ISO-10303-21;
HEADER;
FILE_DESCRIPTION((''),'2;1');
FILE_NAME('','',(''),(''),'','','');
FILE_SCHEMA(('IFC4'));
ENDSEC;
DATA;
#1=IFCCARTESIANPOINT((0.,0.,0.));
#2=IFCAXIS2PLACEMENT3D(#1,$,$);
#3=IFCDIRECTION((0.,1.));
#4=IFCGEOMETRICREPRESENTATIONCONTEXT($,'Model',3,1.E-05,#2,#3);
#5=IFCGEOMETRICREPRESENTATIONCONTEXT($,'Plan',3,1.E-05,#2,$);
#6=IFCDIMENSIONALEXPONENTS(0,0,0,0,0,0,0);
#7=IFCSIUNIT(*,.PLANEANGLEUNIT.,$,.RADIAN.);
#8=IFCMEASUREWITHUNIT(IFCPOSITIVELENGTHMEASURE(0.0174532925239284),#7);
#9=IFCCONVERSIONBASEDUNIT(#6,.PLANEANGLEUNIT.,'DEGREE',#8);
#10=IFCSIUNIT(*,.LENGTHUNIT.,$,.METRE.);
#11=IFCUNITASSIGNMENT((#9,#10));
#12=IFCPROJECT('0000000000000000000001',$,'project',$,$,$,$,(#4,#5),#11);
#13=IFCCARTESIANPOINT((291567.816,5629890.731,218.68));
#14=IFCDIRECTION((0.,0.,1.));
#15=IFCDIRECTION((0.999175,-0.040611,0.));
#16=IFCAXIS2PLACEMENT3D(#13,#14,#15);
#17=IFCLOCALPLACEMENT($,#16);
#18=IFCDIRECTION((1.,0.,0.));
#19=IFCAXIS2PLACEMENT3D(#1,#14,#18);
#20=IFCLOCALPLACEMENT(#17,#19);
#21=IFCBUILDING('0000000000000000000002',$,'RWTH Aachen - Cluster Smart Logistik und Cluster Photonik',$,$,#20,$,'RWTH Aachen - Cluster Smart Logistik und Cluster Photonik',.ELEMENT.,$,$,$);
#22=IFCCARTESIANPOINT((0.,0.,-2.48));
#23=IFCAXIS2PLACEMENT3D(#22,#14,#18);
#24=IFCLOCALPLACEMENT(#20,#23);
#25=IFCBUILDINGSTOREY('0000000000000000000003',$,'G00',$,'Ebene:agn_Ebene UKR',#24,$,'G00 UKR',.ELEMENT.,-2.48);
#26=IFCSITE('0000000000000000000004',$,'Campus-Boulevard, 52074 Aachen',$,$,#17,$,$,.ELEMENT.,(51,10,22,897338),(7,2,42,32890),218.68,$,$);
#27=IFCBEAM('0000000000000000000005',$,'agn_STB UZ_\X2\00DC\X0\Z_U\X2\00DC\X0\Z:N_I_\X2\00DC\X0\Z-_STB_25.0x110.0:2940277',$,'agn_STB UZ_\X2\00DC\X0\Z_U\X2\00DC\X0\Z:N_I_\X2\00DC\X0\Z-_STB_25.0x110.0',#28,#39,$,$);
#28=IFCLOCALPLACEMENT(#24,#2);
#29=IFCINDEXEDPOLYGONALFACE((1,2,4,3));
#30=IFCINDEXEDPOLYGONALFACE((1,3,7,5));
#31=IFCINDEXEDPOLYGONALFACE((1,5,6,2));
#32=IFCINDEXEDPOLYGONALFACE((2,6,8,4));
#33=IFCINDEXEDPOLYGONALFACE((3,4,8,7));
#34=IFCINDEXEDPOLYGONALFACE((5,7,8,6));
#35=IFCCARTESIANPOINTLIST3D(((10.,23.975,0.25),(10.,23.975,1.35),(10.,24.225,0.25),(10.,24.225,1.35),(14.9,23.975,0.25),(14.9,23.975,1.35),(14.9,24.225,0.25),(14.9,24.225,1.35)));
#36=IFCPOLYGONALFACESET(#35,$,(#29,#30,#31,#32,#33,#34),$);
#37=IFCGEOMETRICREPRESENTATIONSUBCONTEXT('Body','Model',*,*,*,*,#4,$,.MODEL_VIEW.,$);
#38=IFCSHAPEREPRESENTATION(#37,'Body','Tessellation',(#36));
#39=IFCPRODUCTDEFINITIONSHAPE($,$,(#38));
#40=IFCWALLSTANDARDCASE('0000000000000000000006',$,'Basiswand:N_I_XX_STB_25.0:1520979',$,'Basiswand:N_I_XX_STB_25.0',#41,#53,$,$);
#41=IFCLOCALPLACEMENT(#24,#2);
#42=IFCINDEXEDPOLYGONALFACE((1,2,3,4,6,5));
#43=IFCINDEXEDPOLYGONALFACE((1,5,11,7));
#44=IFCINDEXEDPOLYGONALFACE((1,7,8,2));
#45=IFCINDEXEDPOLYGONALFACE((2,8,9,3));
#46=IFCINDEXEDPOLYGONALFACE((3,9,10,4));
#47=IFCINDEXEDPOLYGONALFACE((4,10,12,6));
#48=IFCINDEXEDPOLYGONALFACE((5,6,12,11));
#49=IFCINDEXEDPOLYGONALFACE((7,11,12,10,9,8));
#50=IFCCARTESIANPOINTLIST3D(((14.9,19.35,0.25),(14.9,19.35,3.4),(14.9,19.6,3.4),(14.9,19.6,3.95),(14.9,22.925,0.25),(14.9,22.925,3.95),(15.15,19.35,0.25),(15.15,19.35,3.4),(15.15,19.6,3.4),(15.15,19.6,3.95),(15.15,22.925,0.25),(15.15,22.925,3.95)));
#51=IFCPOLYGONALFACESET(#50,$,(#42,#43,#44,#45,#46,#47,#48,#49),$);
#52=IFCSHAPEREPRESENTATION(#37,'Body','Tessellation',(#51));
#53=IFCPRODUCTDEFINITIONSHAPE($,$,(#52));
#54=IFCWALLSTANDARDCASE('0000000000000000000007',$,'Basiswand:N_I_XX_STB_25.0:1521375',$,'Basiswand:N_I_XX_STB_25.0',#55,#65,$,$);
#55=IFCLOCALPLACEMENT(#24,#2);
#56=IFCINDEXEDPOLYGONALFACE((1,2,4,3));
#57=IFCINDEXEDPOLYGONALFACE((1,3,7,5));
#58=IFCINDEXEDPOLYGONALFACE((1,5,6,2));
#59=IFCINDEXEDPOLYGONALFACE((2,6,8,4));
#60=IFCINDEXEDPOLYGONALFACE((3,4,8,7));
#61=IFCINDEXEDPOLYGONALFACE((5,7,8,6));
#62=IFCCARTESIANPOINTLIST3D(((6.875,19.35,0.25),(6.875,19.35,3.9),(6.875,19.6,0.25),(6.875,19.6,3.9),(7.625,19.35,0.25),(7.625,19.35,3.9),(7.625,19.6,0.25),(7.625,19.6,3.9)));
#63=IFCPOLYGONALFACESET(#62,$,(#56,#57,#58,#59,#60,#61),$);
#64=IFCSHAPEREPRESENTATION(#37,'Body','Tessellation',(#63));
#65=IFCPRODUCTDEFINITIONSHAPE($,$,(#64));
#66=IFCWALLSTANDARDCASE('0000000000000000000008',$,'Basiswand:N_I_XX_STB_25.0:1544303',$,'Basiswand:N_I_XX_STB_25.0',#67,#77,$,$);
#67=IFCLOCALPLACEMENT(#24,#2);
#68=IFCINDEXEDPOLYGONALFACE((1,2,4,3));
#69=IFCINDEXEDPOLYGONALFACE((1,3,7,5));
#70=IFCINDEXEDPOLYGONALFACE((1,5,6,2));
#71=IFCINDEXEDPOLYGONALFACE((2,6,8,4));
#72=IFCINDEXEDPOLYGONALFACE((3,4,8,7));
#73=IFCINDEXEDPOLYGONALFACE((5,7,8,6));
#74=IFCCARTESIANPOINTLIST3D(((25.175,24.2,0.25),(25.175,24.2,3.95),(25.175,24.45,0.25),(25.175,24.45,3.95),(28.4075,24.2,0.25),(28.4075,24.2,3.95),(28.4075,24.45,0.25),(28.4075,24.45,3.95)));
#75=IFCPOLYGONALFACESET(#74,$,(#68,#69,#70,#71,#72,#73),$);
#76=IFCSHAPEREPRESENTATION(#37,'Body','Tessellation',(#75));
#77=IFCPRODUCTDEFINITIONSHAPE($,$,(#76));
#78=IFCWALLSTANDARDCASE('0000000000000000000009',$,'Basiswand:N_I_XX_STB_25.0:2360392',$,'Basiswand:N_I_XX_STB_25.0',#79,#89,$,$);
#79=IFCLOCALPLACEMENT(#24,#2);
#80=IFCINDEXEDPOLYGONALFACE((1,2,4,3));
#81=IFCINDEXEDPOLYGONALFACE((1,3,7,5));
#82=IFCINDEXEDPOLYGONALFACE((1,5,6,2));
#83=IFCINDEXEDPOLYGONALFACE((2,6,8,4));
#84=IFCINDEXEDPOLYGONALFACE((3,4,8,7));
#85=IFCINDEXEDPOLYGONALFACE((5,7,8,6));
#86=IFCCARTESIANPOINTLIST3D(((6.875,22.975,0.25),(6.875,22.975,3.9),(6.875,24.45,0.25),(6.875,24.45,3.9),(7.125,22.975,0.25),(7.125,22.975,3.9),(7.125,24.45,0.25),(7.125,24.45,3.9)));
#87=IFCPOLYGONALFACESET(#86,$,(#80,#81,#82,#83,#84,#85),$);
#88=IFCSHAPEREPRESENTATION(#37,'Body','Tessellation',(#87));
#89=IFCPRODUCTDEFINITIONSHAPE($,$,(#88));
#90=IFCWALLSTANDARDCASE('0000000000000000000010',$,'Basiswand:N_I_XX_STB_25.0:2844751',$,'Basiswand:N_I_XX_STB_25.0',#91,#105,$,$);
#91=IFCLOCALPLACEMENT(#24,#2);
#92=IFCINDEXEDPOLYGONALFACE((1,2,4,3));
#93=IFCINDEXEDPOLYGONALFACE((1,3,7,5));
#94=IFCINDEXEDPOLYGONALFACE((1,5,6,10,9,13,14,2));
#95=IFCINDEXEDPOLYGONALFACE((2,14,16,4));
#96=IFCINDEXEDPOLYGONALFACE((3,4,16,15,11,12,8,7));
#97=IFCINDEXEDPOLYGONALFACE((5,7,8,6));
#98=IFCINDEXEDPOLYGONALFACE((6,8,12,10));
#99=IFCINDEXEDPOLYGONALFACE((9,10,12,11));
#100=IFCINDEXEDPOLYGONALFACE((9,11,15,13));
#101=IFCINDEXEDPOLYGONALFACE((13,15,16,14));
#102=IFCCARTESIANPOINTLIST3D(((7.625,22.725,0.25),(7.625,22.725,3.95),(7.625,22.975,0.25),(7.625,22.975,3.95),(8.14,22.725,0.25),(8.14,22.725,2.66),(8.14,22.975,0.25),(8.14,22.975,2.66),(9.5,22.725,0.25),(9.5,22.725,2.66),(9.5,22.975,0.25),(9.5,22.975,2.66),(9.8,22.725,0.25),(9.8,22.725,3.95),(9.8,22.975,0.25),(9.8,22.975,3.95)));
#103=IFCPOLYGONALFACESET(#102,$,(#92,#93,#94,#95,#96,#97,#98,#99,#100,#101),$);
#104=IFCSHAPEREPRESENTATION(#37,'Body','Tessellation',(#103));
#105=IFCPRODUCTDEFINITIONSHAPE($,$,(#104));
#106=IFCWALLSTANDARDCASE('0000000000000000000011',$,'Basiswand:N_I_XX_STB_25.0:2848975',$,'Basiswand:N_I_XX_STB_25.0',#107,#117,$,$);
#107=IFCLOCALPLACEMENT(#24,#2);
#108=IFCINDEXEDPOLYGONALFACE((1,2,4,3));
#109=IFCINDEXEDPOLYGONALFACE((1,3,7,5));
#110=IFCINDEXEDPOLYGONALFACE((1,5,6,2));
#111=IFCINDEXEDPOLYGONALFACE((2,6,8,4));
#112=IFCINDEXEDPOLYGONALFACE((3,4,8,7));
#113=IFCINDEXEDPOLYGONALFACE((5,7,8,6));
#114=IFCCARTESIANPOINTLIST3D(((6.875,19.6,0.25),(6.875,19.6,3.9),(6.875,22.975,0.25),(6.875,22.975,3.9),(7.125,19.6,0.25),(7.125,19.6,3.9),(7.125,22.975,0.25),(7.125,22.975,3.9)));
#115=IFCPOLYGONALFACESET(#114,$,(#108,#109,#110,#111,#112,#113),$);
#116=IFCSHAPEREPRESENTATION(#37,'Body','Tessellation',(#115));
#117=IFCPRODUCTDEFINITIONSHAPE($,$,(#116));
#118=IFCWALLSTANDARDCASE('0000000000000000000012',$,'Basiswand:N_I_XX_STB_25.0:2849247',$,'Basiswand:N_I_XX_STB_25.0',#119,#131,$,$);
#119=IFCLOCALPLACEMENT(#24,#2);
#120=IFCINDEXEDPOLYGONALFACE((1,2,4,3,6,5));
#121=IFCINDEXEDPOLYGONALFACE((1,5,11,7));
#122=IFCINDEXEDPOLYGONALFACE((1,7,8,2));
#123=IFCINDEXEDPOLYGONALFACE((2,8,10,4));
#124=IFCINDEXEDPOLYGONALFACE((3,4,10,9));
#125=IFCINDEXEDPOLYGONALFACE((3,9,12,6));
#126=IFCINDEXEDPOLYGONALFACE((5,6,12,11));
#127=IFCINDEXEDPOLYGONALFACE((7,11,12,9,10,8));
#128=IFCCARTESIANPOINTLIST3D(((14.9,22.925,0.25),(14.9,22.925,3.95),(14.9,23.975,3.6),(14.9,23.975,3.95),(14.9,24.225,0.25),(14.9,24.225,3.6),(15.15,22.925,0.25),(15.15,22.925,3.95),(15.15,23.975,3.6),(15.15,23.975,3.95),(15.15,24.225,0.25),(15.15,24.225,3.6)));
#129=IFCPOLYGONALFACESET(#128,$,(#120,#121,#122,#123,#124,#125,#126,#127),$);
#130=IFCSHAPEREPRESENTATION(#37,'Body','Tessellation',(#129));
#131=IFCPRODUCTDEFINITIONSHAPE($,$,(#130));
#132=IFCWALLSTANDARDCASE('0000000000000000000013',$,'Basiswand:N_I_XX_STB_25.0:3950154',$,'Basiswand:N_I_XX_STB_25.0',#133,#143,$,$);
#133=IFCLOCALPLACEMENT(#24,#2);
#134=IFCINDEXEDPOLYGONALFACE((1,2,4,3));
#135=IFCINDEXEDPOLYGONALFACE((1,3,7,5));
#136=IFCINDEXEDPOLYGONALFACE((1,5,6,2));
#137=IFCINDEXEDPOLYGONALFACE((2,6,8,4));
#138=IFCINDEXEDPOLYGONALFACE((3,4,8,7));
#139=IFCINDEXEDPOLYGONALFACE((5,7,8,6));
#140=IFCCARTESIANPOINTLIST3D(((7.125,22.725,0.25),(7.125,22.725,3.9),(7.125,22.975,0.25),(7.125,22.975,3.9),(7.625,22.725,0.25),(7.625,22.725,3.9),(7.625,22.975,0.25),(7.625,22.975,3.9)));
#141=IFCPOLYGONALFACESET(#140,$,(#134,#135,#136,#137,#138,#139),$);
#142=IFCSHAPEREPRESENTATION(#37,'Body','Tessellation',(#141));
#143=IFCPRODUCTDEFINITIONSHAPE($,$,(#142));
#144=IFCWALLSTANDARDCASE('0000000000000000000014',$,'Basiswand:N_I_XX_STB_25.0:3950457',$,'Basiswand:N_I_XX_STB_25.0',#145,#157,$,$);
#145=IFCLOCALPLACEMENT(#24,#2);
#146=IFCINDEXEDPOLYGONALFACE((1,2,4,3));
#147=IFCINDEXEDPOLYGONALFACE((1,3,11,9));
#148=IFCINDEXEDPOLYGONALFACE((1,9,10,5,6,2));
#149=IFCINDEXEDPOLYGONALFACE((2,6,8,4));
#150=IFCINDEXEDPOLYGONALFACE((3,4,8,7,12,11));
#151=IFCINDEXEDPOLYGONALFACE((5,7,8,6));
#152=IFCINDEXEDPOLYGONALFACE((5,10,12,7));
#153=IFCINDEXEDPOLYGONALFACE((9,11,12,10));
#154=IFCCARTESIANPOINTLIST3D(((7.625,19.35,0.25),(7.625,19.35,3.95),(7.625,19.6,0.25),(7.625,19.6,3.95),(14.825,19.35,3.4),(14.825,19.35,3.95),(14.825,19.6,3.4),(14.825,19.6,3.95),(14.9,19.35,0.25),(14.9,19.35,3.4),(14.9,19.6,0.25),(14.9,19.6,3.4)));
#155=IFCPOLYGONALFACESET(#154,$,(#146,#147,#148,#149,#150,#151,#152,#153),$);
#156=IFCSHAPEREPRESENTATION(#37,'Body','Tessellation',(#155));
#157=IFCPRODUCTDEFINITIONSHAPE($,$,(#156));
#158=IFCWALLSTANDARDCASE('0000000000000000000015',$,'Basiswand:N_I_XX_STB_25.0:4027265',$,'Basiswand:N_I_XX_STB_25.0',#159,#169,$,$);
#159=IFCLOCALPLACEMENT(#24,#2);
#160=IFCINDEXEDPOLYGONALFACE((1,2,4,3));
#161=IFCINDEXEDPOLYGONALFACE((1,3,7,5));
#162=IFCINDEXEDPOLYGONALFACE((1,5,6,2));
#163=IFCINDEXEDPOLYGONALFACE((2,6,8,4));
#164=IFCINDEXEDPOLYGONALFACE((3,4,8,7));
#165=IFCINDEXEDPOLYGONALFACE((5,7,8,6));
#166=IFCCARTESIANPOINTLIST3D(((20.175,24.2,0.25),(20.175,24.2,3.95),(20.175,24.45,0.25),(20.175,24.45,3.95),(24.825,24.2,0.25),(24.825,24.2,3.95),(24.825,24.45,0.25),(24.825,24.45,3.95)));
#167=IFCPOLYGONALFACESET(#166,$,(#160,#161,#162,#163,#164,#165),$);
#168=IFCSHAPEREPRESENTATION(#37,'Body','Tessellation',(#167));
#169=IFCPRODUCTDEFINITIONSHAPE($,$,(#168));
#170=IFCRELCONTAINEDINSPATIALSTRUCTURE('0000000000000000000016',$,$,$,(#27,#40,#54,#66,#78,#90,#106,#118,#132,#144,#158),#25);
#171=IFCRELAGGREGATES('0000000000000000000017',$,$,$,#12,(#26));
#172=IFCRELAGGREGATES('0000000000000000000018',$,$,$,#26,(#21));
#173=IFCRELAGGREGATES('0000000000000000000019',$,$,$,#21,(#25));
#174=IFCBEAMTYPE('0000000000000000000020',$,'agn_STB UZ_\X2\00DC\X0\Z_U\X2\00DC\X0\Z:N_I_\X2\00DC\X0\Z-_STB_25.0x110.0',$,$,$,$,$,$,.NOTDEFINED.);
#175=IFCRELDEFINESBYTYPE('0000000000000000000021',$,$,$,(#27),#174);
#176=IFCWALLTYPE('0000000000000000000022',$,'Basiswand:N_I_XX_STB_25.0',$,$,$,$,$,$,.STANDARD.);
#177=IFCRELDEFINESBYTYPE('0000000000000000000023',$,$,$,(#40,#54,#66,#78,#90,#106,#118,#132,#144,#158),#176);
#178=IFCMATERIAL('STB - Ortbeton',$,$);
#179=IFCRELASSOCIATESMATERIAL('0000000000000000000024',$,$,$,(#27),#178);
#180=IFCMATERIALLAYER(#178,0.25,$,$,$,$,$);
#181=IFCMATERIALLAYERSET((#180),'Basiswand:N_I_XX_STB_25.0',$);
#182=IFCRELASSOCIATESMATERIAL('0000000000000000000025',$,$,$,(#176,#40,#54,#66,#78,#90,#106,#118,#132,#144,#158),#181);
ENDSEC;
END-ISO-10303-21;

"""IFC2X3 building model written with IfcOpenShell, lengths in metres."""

from ifc_helpers import new_model, entity, si_unit, converted_unit, direction, frame, frame_2d, origin, origin_with_axes, place, context, subcontext, project, spatial, polyline, rectangle, extrude, clip, bounded_halfspace, material, layer, layer_set, layer_usage, type_object, element, save


model = new_model("IFC2X3")

# Units and contexts
model_context = context("Model", 3, precision=1e-05, world=origin(), true_north=direction((0.0, 1.0)))
plan_context = context("Plan", 3, precision=1e-05, world=origin())
body_context = subcontext(model_context, "Body", "Model", "MODEL_VIEW")
ifc_project = project(units=[converted_unit("PLANEANGLEUNIT", "DEGREE", entity("IfcPositiveLengthMeasure", 0.0174532925239284), si_unit("PLANEANGLEUNIT", "RADIAN"), dimensions=[0, 0, 0, 0, 0, 0, 0]), si_unit("LENGTHUNIT", "METRE")], contexts=[model_context, plan_context])

# Site, building, storey
site_placement = place(None, frame((291567.816, 5629890.731, 218.68), z_axis=(0.0, 0.0, 1.0), x_axis=(0.999175, -0.040611, 0.0)))
site = spatial("IfcSite", under=ifc_project, at=site_placement, Name="Campus-Boulevard, 52074 Aachen", CompositionType="ELEMENT", RefLatitude=(51, 10, 22, 897338), RefLongitude=(7, 2, 42, 32890), RefElevation=218.68)
building_placement = place(site_placement, origin_with_axes())
building = spatial("IfcBuilding", under=site, at=building_placement, Name="RWTH Aachen - Cluster Smart Logistik und Cluster Photonik", LongName="RWTH Aachen - Cluster Smart Logistik und Cluster Photonik", CompositionType="ELEMENT")
storey_placement = place(building_placement, frame((0.0, 0.0, -2.48), z_axis=(0.0, 0.0, 1.0), x_axis=(1.0, 0.0, 0.0)))
storey = spatial("IfcBuildingStorey", under=building, at=storey_placement, Name="G00", ObjectType="Ebene:agn_Ebene UKR", LongName="G00 UKR", CompositionType="ELEMENT", Elevation=-2.48)

# Beam
ifc_material_1 = material(Name="STB - Ortbeton")
beam_type_1 = type_object("IfcBeamType", Name="agn_STB UZ_ÜZ_UÜZ:N_I_ÜZ-_STB_25.0x110.0", PredefinedType="NOTDEFINED")
beam_1_placement = place(storey_placement, frame((15.025, 24.1, 0.25), z_axis=(0.0, 0.0, 1.0), x_axis=(-1.0, 0.0, 0.0)))
element("IfcBeam", 1, at=beam_1_placement, inside=storey, type_object=beam_type_1, material=ifc_material_1, Name="agn_STB UZ_ÜZ_UÜZ:N_I_ÜZ-_STB_25.0x110.0:2940277", ObjectType="agn_STB UZ_ÜZ_UÜZ:N_I_ÜZ-_STB_25.0x110.0", context=body_context, shape_type="SweptSolid", body=[
    extrude(rectangle(XDim=1.1, YDim=0.25, at=frame_2d((0.0, 0.0), x_axis=(1.0, 0.0))), frame((0.125, 0.0, 0.55), z_axis=(1.0, 0.0, 0.0), x_axis=(0.0, 0.0, -1.0)), (0.0, 0.0, 1.0), 4.9),
])

# Walls
ifc_layer_1 = layer(ifc_material_1, 0.25)
ifc_layer_set_1 = layer_set([ifc_layer_1], Name="Basiswand:N_I_XX_STB_25.0")
ifc_layer_usage_1 = layer_usage(ifc_layer_set_1, "AXIS2", "NEGATIVE", 0.125)
wall_type_1 = type_object("IfcWallType", Name="Basiswand:N_I_XX_STB_25.0", PredefinedType="STANDARD", material=ifc_layer_set_1)
wall_1_placement = place(storey_placement, frame((15.025, 19.35, 0.25), z_axis=(0.0, 0.0, 1.0), x_axis=(0.0, 1.0, 0.0)))
element("IfcWallStandardCase", 2, at=wall_1_placement, inside=storey, type_object=wall_type_1, material=ifc_layer_usage_1, Name="Basiswand:N_I_XX_STB_25.0:1520979", ObjectType="Basiswand:N_I_XX_STB_25.0", context=body_context, shape_type="Clipping", body=[
    clip(clip(extrude(rectangle(XDim=3.575, YDim=0.25, at=frame_2d((1.7875, 0.0), x_axis=(-1.0, 0.0))), origin(), (0.0, 0.0, 1.0), 3.7), bounded_halfspace(frame((0.25, -0.125, 3.15), z_axis=(0.0, 0.0, 1.0), x_axis=(0.0, 1.0, 0.0)), False, frame((0.25, -0.125, 3.15), z_axis=(0.0, 0.0, 1.0), x_axis=(0.0, 1.0, 0.0)), polyline([(0.0, 0.0), (0.25, 0.0), (0.25, 0.25), (0.0, 0.25), (0.0, 0.0)]))), bounded_halfspace(frame((0.25, 0.125, 3.15), z_axis=(-1.0, 0.0, 0.0), x_axis=(0.0, -1.0, 0.0)), False, frame((0.25, 0.125, 3.15), z_axis=(-1.0, 0.0, 0.0), x_axis=(0.0, -1.0, 0.0)), polyline([(0.0, 0.0), (0.25, 0.0), (0.25, 0.55), (0.0, 0.55), (0.0, 0.0)]))),
])
ifc_layer_usage_2 = layer_usage(ifc_layer_set_1, "AXIS2", "NEGATIVE", 0.125)
wall_2_placement = place(storey_placement, frame((6.875, 19.475, 0.25), z_axis=(0.0, 0.0, 1.0), x_axis=(1.0, 0.0, 0.0)))
element("IfcWallStandardCase", 3, at=wall_2_placement, inside=storey, type_object=wall_type_1, material=ifc_layer_usage_2, Name="Basiswand:N_I_XX_STB_25.0:1521375", ObjectType="Basiswand:N_I_XX_STB_25.0", context=body_context, shape_type="SweptSolid", body=[
    extrude(rectangle(XDim=0.75, YDim=0.25, at=frame_2d((0.375, 0.0), x_axis=(-1.0, 0.0))), origin(), (0.0, 0.0, 1.0), 3.65),
])
ifc_layer_usage_3 = layer_usage(ifc_layer_set_1, "AXIS2", "NEGATIVE", 0.125)
wall_3_placement = place(storey_placement, frame((28.4075, 24.325, 0.25), z_axis=(0.0, 0.0, 1.0), x_axis=(-1.0, 0.0, 0.0)))
element("IfcWallStandardCase", 4, at=wall_3_placement, inside=storey, type_object=wall_type_1, material=ifc_layer_usage_3, Name="Basiswand:N_I_XX_STB_25.0:1544303", ObjectType="Basiswand:N_I_XX_STB_25.0", context=body_context, shape_type="SweptSolid", body=[
    extrude(rectangle(XDim=3.2325, YDim=0.25, at=frame_2d((1.6162, 0.0), x_axis=(-1.0, 0.0))), origin(), (0.0, 0.0, 1.0), 3.7),
])
ifc_layer_usage_4 = layer_usage(ifc_layer_set_1, "AXIS2", "NEGATIVE", 0.125)
wall_4_placement = place(storey_placement, frame((7.0, 24.45, 0.25), z_axis=(0.0, 0.0, 1.0), x_axis=(0.0, -1.0, 0.0)))
element("IfcWallStandardCase", 5, at=wall_4_placement, inside=storey, type_object=wall_type_1, material=ifc_layer_usage_4, Name="Basiswand:N_I_XX_STB_25.0:2360392", ObjectType="Basiswand:N_I_XX_STB_25.0", context=body_context, shape_type="SweptSolid", body=[
    extrude(rectangle(XDim=1.475, YDim=0.25, at=frame_2d((0.7375, 0.0), x_axis=(-1.0, 0.0))), origin(), (0.0, 0.0, 1.0), 3.65),
])

# Wall, opening
ifc_layer_usage_5 = layer_usage(ifc_layer_set_1, "AXIS2", "NEGATIVE", 0.125)
wall_5_placement = place(storey_placement, frame((9.8, 22.85, 0.25), z_axis=(0.0, 0.0, 1.0), x_axis=(-1.0, 0.0, 0.0)))
wall_5 = element("IfcWallStandardCase", 6, at=wall_5_placement, inside=storey, type_object=wall_type_1, material=ifc_layer_usage_5, Name="Basiswand:N_I_XX_STB_25.0:2844751", ObjectType="Basiswand:N_I_XX_STB_25.0", context=body_context, shape_type="SweptSolid", body=[
    extrude(rectangle(XDim=2.175, YDim=0.25, at=frame_2d((1.0875, 0.0), x_axis=(-1.0, 0.0))), origin(), (0.0, 0.0, 1.0), 3.7),
])
opening_1_placement = place(wall_5_placement, frame((1.66, 0.125, 0.0), z_axis=(0.0, 0.0, 1.0), x_axis=(1.0, 0.0, 0.0)))
element("IfcOpeningElement", 7, at=opening_1_placement, cuts=wall_5, ObjectType="Opening", context=body_context, shape_type="SweptSolid", body=[
    extrude(rectangle(XDim=2.41, YDim=1.36, at=frame_2d((1.205, 0.68), x_axis=(1.0, 0.0))), frame((0.0, 0.0, 0.0), z_axis=(0.0, -1.0, 0.0), x_axis=(0.0, 0.0, 1.0)), (0.0, 0.0, 1.0), 0.25),
])

# Walls
ifc_layer_usage_6 = layer_usage(ifc_layer_set_1, "AXIS2", "NEGATIVE", 0.125)
wall_6_placement = place(storey_placement, frame((7.0, 22.975, 0.25), z_axis=(0.0, 0.0, 1.0), x_axis=(0.0, -1.0, 0.0)))
element("IfcWallStandardCase", 8, at=wall_6_placement, inside=storey, type_object=wall_type_1, material=ifc_layer_usage_6, Name="Basiswand:N_I_XX_STB_25.0:2848975", ObjectType="Basiswand:N_I_XX_STB_25.0", context=body_context, shape_type="SweptSolid", body=[
    extrude(rectangle(XDim=3.375, YDim=0.25, at=frame_2d((1.6875, 0.0), x_axis=(-1.0, 0.0))), origin(), (0.0, 0.0, 1.0), 3.65),
])
ifc_layer_usage_7 = layer_usage(ifc_layer_set_1, "AXIS2", "NEGATIVE", 0.125)
wall_7_placement = place(storey_placement, frame((15.025, 22.925, 0.25), z_axis=(0.0, 0.0, 1.0), x_axis=(0.0, 1.0, 0.0)))
element("IfcWallStandardCase", 9, at=wall_7_placement, inside=storey, type_object=wall_type_1, material=ifc_layer_usage_7, Name="Basiswand:N_I_XX_STB_25.0:2849247", ObjectType="Basiswand:N_I_XX_STB_25.0", context=body_context, shape_type="Clipping", body=[
    clip(clip(extrude(rectangle(XDim=1.3, YDim=0.25, at=frame_2d((0.65, 0.0), x_axis=(-1.0, 0.0))), origin(), (0.0, 0.0, 1.0), 3.7), bounded_halfspace(frame((1.05, -0.125, 3.35), z_axis=(-1.0, 0.0, 0.0), x_axis=(0.0, 0.0, 1.0)), True, frame((1.05, -0.125, 3.35), z_axis=(-1.0, 0.0, 0.0), x_axis=(0.0, 0.0, 1.0)), polyline([(0.0, 0.0), (0.35, 0.0), (0.35, 0.25), (0.0, 0.25), (0.0, 0.0)]))), bounded_halfspace(frame((1.05, 0.125, 3.35), z_axis=(0.0, 0.0, -1.0), x_axis=(-1.0, 0.0, 0.0)), True, frame((1.05, 0.125, 3.35), z_axis=(0.0, 0.0, -1.0), x_axis=(-1.0, 0.0, 0.0)), polyline([(0.0, 0.0), (-0.25, 0.0), (-0.25, -0.25), (0.0, -0.25), (0.0, 0.0)]))),
])
ifc_layer_usage_8 = layer_usage(ifc_layer_set_1, "AXIS2", "NEGATIVE", 0.125)
wall_8_placement = place(storey_placement, frame((7.625, 22.85, 0.25), z_axis=(0.0, 0.0, 1.0), x_axis=(-1.0, 0.0, 0.0)))
element("IfcWallStandardCase", 10, at=wall_8_placement, inside=storey, type_object=wall_type_1, material=ifc_layer_usage_8, Name="Basiswand:N_I_XX_STB_25.0:3950154", ObjectType="Basiswand:N_I_XX_STB_25.0", context=body_context, shape_type="SweptSolid", body=[
    extrude(rectangle(XDim=0.5, YDim=0.25, at=frame_2d((0.25, 0.0), x_axis=(-1.0, 0.0))), origin(), (0.0, 0.0, 1.0), 3.65),
])
ifc_layer_usage_9 = layer_usage(ifc_layer_set_1, "AXIS2", "NEGATIVE", 0.125)
wall_9_placement = place(storey_placement, frame((7.625, 19.475, 0.25), z_axis=(0.0, 0.0, 1.0), x_axis=(1.0, 0.0, 0.0)))
element("IfcWallStandardCase", 11, at=wall_9_placement, inside=storey, type_object=wall_type_1, material=ifc_layer_usage_9, Name="Basiswand:N_I_XX_STB_25.0:3950457", ObjectType="Basiswand:N_I_XX_STB_25.0", context=body_context, shape_type="Clipping", body=[
    clip(clip(extrude(rectangle(XDim=7.275, YDim=0.25, at=frame_2d((3.6375, 0.0), x_axis=(-1.0, 0.0))), origin(), (0.0, 0.0, 1.0), 3.7), bounded_halfspace(frame((7.2, 0.125, 3.15), z_axis=(0.0, 0.0, 1.0), x_axis=(-1.0, 0.0, 0.0)), False, frame((7.2, 0.125, 3.15), z_axis=(0.0, 0.0, 1.0), x_axis=(-1.0, 0.0, 0.0)), polyline([(0.0, 0.0), (0.0, 0.25), (-0.075, 0.25), (-0.075, 0.0), (0.0, 0.0)]))), bounded_halfspace(frame((7.2, -0.125, 3.15), z_axis=(1.0, 0.0, 0.0), x_axis=(0.0, 0.0, 1.0)), False, frame((7.2, -0.125, 3.15), z_axis=(1.0, 0.0, 0.0), x_axis=(0.0, 0.0, 1.0)), polyline([(0.0, 0.0), (0.0, -0.25), (0.55, -0.25), (0.55, 0.0), (0.0, 0.0)]))),
])
ifc_layer_usage_10 = layer_usage(ifc_layer_set_1, "AXIS2", "NEGATIVE", 0.125)
wall_10_placement = place(storey_placement, frame((24.825, 24.325, 0.25), z_axis=(0.0, 0.0, 1.0), x_axis=(-1.0, 0.0, 0.0)))
element("IfcWallStandardCase", 12, at=wall_10_placement, inside=storey, type_object=wall_type_1, material=ifc_layer_usage_10, Name="Basiswand:N_I_XX_STB_25.0:4027265", ObjectType="Basiswand:N_I_XX_STB_25.0", context=body_context, shape_type="SweptSolid", body=[
    extrude(rectangle(XDim=4.65, YDim=0.25, at=frame_2d((2.325, 0.0), x_axis=(-1.0, 0.0))), origin(), (0.0, 0.0, 1.0), 3.7),
])

save(model, "model.ifc")
